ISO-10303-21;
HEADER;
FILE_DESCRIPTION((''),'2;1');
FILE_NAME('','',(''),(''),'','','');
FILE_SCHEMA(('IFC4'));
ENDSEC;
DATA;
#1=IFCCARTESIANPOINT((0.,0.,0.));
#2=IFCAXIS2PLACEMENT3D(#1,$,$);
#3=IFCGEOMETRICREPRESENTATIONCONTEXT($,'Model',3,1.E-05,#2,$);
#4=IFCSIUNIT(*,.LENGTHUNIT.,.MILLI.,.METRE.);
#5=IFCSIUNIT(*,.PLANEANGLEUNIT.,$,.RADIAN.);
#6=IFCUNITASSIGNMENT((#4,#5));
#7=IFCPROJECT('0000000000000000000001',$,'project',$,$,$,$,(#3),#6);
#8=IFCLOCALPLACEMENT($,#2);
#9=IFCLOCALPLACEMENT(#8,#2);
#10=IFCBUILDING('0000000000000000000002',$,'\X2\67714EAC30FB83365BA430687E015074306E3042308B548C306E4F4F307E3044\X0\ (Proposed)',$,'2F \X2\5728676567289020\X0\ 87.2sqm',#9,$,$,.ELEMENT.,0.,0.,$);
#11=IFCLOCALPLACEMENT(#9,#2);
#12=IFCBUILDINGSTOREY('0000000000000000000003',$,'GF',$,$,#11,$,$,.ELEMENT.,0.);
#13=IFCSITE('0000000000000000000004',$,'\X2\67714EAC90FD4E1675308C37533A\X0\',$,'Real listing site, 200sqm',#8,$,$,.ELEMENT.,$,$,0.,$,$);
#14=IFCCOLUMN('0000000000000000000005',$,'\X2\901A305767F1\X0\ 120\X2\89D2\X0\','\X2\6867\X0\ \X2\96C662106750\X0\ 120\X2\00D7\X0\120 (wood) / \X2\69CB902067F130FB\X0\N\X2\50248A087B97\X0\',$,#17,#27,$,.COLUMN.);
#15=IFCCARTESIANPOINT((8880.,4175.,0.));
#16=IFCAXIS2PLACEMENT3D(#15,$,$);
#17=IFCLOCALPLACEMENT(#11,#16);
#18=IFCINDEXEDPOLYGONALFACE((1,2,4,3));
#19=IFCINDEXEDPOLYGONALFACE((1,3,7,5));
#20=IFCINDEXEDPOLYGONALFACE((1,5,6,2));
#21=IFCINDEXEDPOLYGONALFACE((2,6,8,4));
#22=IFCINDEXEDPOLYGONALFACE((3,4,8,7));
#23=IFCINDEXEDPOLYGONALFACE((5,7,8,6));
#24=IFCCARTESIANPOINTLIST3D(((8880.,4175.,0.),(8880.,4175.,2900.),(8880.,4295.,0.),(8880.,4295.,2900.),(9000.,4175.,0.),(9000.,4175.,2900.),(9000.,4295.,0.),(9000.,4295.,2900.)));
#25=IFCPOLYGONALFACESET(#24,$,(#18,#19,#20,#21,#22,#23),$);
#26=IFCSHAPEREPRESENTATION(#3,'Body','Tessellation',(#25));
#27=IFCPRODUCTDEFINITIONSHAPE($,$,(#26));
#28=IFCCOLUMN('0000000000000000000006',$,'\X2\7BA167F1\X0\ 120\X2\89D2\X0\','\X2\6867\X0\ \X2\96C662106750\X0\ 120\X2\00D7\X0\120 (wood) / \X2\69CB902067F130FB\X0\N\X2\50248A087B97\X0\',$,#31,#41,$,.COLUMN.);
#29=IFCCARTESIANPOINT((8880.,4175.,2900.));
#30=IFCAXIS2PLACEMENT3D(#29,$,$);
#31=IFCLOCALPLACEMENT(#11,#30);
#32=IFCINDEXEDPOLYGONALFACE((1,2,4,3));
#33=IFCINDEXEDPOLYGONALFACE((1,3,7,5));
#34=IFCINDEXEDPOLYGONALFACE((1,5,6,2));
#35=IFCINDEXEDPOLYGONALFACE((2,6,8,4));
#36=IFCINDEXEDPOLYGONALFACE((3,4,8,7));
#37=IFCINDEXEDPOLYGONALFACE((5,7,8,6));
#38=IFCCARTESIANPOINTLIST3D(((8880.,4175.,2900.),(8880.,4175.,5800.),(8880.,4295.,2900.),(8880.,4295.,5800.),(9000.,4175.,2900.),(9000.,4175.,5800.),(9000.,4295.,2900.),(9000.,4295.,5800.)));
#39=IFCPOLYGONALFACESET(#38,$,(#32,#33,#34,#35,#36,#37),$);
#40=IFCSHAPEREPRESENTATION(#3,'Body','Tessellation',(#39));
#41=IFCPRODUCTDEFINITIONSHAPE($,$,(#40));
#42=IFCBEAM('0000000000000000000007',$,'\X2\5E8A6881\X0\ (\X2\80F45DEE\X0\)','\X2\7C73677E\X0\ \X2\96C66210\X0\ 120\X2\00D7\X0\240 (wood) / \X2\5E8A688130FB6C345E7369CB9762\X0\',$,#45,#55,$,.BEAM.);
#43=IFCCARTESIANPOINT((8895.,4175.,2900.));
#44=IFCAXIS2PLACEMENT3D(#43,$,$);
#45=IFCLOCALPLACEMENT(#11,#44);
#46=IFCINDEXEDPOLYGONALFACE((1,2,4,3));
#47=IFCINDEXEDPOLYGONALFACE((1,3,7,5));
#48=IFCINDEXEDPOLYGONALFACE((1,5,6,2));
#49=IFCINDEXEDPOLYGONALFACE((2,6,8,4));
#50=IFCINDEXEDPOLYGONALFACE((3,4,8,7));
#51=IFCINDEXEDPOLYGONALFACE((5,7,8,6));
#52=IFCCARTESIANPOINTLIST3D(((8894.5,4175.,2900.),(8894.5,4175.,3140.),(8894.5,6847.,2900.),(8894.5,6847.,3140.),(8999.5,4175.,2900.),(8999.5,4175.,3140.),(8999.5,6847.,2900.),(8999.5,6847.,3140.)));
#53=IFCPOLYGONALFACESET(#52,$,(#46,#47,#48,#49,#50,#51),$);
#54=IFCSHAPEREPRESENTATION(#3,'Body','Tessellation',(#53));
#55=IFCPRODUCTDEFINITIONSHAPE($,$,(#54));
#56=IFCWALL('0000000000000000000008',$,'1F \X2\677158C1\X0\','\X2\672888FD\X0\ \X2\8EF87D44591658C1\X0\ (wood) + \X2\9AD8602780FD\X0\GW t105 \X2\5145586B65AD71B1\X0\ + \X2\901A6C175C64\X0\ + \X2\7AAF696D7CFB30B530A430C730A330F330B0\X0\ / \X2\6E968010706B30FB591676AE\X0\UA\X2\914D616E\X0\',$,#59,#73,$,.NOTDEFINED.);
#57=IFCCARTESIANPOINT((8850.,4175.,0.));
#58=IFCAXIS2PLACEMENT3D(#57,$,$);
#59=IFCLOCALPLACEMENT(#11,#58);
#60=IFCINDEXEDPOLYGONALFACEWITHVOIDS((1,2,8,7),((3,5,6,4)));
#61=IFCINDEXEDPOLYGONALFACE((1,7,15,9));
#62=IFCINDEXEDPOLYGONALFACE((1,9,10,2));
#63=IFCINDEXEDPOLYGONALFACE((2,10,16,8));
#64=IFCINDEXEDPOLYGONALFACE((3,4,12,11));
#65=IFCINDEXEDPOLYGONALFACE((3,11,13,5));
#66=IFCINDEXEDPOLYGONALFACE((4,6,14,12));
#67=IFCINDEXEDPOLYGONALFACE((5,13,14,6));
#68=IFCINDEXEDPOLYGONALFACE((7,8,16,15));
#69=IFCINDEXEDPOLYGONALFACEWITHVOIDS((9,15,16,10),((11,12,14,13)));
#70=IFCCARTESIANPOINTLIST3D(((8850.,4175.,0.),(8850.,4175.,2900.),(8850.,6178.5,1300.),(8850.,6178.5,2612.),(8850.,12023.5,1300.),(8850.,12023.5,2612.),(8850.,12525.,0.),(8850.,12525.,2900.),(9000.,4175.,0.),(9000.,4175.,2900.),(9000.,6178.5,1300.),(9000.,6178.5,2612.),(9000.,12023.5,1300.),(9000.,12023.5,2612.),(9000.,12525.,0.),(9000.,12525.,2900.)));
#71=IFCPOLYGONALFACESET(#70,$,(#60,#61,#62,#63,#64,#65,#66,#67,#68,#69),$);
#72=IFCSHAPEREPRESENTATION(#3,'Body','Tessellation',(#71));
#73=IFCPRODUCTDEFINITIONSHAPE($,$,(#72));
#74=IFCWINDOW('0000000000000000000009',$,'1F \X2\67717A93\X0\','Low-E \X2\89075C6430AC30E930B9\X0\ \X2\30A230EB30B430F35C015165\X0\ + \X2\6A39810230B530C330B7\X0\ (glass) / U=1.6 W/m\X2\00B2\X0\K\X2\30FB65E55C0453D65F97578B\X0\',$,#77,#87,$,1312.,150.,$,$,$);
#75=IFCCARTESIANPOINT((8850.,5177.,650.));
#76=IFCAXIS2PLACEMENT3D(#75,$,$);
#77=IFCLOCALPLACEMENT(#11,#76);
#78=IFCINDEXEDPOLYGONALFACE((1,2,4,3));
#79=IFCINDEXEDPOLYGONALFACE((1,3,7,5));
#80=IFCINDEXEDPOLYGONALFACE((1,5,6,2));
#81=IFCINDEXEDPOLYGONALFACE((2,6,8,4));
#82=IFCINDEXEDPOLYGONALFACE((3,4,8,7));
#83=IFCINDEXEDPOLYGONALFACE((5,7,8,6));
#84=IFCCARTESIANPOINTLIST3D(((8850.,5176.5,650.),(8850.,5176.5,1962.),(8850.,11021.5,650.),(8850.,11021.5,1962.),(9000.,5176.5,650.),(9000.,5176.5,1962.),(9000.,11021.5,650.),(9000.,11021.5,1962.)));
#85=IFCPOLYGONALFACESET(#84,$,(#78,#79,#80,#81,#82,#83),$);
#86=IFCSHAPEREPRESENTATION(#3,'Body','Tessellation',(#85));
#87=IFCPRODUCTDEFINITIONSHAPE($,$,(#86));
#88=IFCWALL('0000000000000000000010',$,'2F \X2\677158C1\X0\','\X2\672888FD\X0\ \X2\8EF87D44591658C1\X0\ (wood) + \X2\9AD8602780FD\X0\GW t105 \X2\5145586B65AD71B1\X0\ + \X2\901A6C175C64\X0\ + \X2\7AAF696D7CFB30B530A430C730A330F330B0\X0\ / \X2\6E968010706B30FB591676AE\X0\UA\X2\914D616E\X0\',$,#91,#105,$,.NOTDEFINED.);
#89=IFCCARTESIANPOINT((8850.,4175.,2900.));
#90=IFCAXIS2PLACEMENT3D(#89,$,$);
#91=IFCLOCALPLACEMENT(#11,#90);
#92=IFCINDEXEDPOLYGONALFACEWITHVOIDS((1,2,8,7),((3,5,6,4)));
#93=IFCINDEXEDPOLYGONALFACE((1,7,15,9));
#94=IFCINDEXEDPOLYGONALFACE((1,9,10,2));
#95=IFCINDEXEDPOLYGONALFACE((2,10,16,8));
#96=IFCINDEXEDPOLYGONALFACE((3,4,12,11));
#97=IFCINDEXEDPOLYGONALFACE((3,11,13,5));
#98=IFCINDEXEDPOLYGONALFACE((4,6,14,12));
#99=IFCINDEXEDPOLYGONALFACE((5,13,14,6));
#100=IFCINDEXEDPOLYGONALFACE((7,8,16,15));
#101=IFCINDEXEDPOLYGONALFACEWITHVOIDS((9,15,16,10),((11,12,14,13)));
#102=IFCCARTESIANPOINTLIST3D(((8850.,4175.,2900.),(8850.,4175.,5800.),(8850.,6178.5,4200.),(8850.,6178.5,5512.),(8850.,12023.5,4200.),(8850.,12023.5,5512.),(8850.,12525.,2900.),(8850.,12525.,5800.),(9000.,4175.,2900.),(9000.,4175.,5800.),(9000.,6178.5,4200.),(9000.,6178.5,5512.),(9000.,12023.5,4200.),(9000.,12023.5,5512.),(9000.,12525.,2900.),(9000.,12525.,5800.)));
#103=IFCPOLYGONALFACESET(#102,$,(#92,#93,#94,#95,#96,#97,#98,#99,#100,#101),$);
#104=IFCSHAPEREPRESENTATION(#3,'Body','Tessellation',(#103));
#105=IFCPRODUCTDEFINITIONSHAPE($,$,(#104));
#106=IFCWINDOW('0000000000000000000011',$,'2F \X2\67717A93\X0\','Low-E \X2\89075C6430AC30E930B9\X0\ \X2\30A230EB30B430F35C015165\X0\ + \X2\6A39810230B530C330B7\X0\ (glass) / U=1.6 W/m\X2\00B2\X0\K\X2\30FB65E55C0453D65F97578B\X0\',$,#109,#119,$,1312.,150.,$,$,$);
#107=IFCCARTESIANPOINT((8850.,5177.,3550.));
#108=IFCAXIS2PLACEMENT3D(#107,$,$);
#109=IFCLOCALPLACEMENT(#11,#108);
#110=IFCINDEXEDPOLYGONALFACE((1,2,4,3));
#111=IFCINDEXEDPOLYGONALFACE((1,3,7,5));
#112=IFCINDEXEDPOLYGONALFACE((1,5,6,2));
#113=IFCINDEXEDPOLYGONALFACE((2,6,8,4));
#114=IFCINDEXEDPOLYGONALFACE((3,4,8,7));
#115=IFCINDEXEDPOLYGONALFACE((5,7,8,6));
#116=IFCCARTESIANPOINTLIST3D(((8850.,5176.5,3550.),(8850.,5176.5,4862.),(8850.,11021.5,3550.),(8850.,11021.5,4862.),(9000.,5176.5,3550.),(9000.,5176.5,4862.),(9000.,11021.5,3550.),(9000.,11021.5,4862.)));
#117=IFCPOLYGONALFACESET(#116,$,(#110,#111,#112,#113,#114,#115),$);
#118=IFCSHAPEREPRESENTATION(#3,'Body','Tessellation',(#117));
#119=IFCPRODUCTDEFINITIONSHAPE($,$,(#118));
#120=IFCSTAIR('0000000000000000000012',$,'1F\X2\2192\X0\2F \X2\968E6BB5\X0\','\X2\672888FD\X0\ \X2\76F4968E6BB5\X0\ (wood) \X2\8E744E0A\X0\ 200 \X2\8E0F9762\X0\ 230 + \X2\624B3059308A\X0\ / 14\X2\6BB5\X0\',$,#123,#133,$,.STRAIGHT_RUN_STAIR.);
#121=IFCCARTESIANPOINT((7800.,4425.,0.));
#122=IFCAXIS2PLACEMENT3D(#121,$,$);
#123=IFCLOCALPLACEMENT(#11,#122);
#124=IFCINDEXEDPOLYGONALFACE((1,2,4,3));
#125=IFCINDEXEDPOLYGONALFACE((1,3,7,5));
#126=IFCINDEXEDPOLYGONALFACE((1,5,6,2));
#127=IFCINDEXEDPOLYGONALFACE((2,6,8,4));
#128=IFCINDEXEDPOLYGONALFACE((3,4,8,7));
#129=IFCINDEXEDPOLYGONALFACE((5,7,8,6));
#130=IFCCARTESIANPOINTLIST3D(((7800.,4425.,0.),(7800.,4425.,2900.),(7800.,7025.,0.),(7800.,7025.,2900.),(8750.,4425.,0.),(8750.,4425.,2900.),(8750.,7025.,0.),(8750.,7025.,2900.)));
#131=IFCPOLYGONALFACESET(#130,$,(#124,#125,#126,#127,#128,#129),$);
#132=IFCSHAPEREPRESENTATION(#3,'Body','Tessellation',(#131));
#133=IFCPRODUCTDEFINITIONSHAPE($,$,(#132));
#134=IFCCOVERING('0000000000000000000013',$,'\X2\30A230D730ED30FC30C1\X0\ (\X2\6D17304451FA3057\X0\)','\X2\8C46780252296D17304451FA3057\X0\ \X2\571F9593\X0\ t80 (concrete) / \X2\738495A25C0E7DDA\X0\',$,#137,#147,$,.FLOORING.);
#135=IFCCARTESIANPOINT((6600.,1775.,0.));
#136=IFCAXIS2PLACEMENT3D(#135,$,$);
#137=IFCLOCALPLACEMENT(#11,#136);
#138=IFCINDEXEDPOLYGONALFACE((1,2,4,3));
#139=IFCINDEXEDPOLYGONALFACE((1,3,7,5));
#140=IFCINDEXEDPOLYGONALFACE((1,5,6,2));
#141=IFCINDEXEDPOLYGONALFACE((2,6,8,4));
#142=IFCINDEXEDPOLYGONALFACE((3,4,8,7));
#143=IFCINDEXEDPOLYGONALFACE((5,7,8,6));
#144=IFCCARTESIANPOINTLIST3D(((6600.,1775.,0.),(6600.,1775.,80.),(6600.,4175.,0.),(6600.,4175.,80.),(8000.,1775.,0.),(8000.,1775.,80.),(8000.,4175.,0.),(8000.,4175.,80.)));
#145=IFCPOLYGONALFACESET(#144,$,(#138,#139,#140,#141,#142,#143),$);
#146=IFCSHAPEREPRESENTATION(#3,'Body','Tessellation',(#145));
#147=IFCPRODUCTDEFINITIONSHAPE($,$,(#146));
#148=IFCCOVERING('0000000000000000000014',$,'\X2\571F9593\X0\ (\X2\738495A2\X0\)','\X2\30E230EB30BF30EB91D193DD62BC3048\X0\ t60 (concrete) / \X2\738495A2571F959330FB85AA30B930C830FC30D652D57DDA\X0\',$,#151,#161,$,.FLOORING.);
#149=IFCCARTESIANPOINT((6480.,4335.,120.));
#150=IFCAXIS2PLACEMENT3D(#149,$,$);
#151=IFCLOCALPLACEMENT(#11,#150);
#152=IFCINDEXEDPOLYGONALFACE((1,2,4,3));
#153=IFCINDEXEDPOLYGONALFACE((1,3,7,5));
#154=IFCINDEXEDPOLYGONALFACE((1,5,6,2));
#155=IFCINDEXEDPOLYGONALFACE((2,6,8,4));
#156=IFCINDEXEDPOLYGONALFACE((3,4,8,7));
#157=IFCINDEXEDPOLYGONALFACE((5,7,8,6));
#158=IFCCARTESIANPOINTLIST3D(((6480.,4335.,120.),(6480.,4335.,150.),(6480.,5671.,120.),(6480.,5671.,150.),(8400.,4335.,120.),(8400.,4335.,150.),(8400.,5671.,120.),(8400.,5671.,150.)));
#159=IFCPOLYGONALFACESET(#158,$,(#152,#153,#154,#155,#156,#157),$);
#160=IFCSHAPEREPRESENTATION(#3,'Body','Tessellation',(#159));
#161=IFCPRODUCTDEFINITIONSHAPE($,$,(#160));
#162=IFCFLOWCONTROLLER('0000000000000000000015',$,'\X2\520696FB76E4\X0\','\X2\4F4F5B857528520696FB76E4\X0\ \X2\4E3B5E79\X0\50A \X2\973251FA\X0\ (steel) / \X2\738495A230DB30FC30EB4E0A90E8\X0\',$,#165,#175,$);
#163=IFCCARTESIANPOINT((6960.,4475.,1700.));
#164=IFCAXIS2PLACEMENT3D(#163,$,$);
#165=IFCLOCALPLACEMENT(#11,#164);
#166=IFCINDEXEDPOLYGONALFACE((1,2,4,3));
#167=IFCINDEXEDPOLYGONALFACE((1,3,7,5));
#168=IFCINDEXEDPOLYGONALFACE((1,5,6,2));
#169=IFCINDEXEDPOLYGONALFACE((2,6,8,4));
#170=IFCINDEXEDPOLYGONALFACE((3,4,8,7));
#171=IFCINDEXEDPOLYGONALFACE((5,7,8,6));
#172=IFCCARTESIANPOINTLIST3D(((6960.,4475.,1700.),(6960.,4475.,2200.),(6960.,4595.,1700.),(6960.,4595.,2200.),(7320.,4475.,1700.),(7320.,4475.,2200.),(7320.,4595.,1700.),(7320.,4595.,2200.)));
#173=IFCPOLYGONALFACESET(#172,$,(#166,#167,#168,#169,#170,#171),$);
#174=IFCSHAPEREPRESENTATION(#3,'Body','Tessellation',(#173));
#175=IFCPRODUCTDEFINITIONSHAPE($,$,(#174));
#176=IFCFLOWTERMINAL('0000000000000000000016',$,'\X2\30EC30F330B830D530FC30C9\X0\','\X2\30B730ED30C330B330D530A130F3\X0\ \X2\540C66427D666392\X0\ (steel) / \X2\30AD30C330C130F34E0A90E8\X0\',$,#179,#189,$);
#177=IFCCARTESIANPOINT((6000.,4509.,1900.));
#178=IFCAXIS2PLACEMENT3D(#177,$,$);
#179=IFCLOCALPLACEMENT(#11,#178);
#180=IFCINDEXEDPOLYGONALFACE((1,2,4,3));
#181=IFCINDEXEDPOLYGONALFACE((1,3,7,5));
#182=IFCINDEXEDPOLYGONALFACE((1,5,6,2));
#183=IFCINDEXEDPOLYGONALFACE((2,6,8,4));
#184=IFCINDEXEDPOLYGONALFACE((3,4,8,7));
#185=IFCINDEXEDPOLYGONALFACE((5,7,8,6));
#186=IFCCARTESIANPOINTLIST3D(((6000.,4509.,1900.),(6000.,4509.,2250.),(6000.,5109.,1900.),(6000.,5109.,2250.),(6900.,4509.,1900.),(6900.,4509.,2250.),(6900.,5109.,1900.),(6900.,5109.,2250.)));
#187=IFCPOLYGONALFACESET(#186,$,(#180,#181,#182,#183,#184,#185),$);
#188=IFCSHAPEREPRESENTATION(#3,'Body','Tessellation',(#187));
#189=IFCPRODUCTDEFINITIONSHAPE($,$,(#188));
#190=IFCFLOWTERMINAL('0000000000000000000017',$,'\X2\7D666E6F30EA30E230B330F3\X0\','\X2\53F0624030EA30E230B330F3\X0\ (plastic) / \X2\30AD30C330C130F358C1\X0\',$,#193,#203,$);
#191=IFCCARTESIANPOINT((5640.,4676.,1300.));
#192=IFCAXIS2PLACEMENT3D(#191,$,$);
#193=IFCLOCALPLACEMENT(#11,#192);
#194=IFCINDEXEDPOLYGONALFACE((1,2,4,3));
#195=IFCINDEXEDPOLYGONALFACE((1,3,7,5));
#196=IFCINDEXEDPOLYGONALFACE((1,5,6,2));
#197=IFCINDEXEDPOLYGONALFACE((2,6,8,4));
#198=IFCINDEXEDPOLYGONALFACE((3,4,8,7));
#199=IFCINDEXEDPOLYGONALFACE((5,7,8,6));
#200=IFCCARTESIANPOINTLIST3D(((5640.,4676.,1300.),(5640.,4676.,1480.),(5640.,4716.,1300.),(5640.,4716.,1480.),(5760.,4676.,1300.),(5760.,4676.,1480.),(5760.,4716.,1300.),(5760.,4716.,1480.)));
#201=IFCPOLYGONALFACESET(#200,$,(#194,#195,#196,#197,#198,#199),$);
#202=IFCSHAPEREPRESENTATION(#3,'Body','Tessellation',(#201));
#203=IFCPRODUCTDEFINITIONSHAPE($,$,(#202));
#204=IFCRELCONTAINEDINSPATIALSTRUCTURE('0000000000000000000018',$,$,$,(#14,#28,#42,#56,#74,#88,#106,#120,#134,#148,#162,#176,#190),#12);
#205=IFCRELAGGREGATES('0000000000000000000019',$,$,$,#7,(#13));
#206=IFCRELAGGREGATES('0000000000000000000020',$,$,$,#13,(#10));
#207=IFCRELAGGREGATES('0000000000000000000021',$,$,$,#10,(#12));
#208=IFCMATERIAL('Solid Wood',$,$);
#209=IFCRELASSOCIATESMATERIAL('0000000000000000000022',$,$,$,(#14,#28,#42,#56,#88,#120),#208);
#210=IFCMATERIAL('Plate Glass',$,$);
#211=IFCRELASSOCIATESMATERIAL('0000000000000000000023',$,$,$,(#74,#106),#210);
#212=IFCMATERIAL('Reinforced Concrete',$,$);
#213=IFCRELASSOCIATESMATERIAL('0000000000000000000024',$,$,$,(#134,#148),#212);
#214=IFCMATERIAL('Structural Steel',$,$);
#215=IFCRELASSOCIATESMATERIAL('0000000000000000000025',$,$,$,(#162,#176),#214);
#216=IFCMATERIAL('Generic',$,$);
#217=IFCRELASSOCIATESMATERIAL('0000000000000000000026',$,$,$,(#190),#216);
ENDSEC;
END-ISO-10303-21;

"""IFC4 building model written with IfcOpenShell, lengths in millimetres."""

from ifc_helpers import new_model, si_unit, frame, frame_2d, origin, place, context, project, spatial, rectangle, extrude, material, element, fill, save


model = new_model("IFC4")

# Units and contexts
model_context = context("Model", 3, precision=1e-05, world=origin())
ifc_project = project(units=[si_unit("LENGTHUNIT", "METRE", prefix="MILLI"), si_unit("PLANEANGLEUNIT", "RADIAN")], contexts=[model_context])

# Site, building, storey
site_placement = place(None, origin())
site = spatial("IfcSite", under=ifc_project, at=site_placement, Name="東京都世田谷区", ObjectType="Real listing site, 200sqm", CompositionType="ELEMENT", RefElevation=0.0)
building_placement = place(site_placement, origin())
building = spatial("IfcBuilding", under=site, at=building_placement, Name="東京・茶室と縁側のある和の住まい (Proposed)", ObjectType="2F 在来木造 87.2sqm", CompositionType="ELEMENT", ElevationOfRefHeight=0.0, ElevationOfTerrain=0.0)
storey_placement = place(building_placement, origin())
storey = spatial("IfcBuildingStorey", under=building, at=storey_placement, Name="GF", CompositionType="ELEMENT", Elevation=0.0)

# Columns
ifc_material_1 = material(Name="Solid Wood")
column_1_placement = place(storey_placement, frame((8880.0, 4175.0, 0.0)))
element("IfcColumn", 1, at=column_1_placement, inside=storey, material=ifc_material_1, Name="通し柱 120角", Description="桧 集成材 120×120 (wood) / 構造柱・N値計算", PredefinedType="COLUMN", context=model_context, shape_type="SweptSolid", body=[
    extrude(rectangle(XDim=120.0, YDim=120.0, at=frame_2d((60.0, 60.0))), frame((8880.0, 4175.0, 0.0)), (0.0, 0.0, 1.0), 2900.0),
])
column_2_placement = place(storey_placement, frame((8880.0, 4175.0, 2900.0)))
element("IfcColumn", 2, at=column_2_placement, inside=storey, material=ifc_material_1, Name="管柱 120角", Description="桧 集成材 120×120 (wood) / 構造柱・N値計算", PredefinedType="COLUMN", context=model_context, shape_type="SweptSolid", body=[
    extrude(rectangle(XDim=120.0, YDim=120.0, at=frame_2d((60.0, 60.0))), frame((8880.0, 4175.0, 2900.0)), (0.0, 0.0, 1.0), 2900.0),
])

# Beam
beam_1_placement = place(storey_placement, frame((8895.0, 4175.0, 2900.0)))
element("IfcBeam", 3, at=beam_1_placement, inside=storey, material=ifc_material_1, Name="床梁 (胴差)", Description="米松 集成 120×240 (wood) / 床梁・水平構面", PredefinedType="BEAM", context=model_context, shape_type="SweptSolid", body=[
    extrude(rectangle(XDim=105.0, YDim=2672.0, at=frame_2d((52.0, 1336.0))), frame((8895.0, 4175.0, 2900.0)), (0.0, 0.0, 1.0), 240.0),
])

# Wall, opening, window
wall_1_placement = place(storey_placement, frame((8850.0, 4175.0, 0.0)))
wall_1 = element("IfcWall", 4, at=wall_1_placement, inside=storey, material=ifc_material_1, Name="1F 東壁", Description="木製 軸組外壁 (wood) + 高性能GW t105 充填断熱 + 通気層 + 窯業系サイディング / 準耐火・外皮UA配慮", PredefinedType="NOTDEFINED", context=model_context, shape_type="SweptSolid", body=[
    extrude(rectangle(XDim=150.0, YDim=8350.0, at=frame_2d((75.0, 4175.0))), frame((8850.0, 4175.0, 0.0)), (0.0, 0.0, 1.0), 2900.0),
])
opening_1_placement = place(storey_placement, frame((8850.0, 5177.0, 650.0)))
opening_1 = element("IfcOpeningElement", 5, at=opening_1_placement, cuts=wall_1, PredefinedType="NOTDEFINED", context=model_context, shape_type="SweptSolid", body=[
    extrude(rectangle(XDim=150.0, YDim=5845.0, at=frame_2d((75.0, 2922.0))), frame((8850.0, 5177.0, 650.0)), (0.0, 0.0, 1.0), 1312.0),
])
ifc_material_2 = material(Name="Plate Glass")
window_1_placement = place(storey_placement, frame((8850.0, 5177.0, 650.0)))
window_1 = element("IfcWindow", 6, at=window_1_placement, inside=storey, material=ifc_material_2, Name="1F 東窓", Description="Low-E 複層ガラス アルゴン封入 + 樹脂サッシ (glass) / U=1.6 W/m²K・日射取得型", OverallHeight=1312.0, OverallWidth=150.0, context=model_context, shape_type="SweptSolid", body=[
    extrude(rectangle(XDim=150.0, YDim=5845.0, at=frame_2d((75.0, 2922.0))), frame((8850.0, 5177.0, 650.0)), (0.0, 0.0, 1.0), 1312.0),
])
fill(opening_1, window_1)

# Wall, opening, window
wall_2_placement = place(storey_placement, frame((8850.0, 4175.0, 2900.0)))
wall_2 = element("IfcWall", 7, at=wall_2_placement, inside=storey, material=ifc_material_1, Name="2F 東壁", Description="木製 軸組外壁 (wood) + 高性能GW t105 充填断熱 + 通気層 + 窯業系サイディング / 準耐火・外皮UA配慮", PredefinedType="NOTDEFINED", context=model_context, shape_type="SweptSolid", body=[
    extrude(rectangle(XDim=150.0, YDim=8350.0, at=frame_2d((75.0, 4175.0))), frame((8850.0, 4175.0, 2900.0)), (0.0, 0.0, 1.0), 2900.0),
])
opening_2_placement = place(storey_placement, frame((8850.0, 5177.0, 3550.0)))
opening_2 = element("IfcOpeningElement", 8, at=opening_2_placement, cuts=wall_2, PredefinedType="NOTDEFINED", context=model_context, shape_type="SweptSolid", body=[
    extrude(rectangle(XDim=150.0, YDim=5845.0, at=frame_2d((75.0, 2922.0))), frame((8850.0, 5177.0, 3550.0)), (0.0, 0.0, 1.0), 1312.0),
])
window_2_placement = place(storey_placement, frame((8850.0, 5177.0, 3550.0)))
window_2 = element("IfcWindow", 9, at=window_2_placement, inside=storey, material=ifc_material_2, Name="2F 東窓", Description="Low-E 複層ガラス アルゴン封入 + 樹脂サッシ (glass) / U=1.6 W/m²K・日射取得型", OverallHeight=1312.0, OverallWidth=150.0, context=model_context, shape_type="SweptSolid", body=[
    extrude(rectangle(XDim=150.0, YDim=5845.0, at=frame_2d((75.0, 2922.0))), frame((8850.0, 5177.0, 3550.0)), (0.0, 0.0, 1.0), 1312.0),
])
fill(opening_2, window_2)

# Stair
stair_placement = place(storey_placement, frame((7800.0, 4425.0, 0.0)))
element("IfcStair", 10, at=stair_placement, inside=storey, material=ifc_material_1, Name="1F→2F 階段", Description="木製 直階段 (wood) 蹴上 200 踏面 230 + 手すり / 14段", PredefinedType="STRAIGHT_RUN_STAIR", context=model_context, shape_type="SweptSolid", body=[
    extrude(rectangle(XDim=950.0, YDim=2600.0, at=frame_2d((475.0, 1300.0))), frame((7800.0, 4425.0, 0.0)), (0.0, 0.0, 1.0), 2900.0),
])

# Coverings
ifc_material_3 = material(Name="Reinforced Concrete")
covering_1_placement = place(storey_placement, frame((6600.0, 1775.0, 0.0)))
element("IfcCovering", 11, at=covering_1_placement, inside=storey, material=ifc_material_3, Name="アプローチ (洗い出し)", Description="豆砂利洗い出し 土間 t80 (concrete) / 玄関導線", PredefinedType="FLOORING", context=model_context, shape_type="SweptSolid", body=[
    extrude(rectangle(XDim=1400.0, YDim=2400.0, at=frame_2d((700.0, 1200.0))), frame((6600.0, 1775.0, 0.0)), (0.0, 0.0, 1.0), 80.0),
])
covering_2_placement = place(storey_placement, frame((6480.0, 4335.0, 120.0)))
element("IfcCovering", 12, at=covering_2_placement, inside=storey, material=ifc_material_3, Name="土間 (玄関)", Description="モルタル金鏝押え t60 (concrete) / 玄関土間・薪ストーブ動線", PredefinedType="FLOORING", context=model_context, shape_type="SweptSolid", body=[
    extrude(rectangle(XDim=1920.0, YDim=1336.0, at=frame_2d((960.0, 668.0))), frame((6480.0, 4335.0, 120.0)), (0.0, 0.0, 1.0), 30.0),
])

# Flow controller
ifc_material_4 = material(Name="Structural Steel")
flow_controller_placement = place(storey_placement, frame((6960.0, 4475.0, 1700.0)))
element("IfcFlowController", 13, at=flow_controller_placement, inside=storey, material=ifc_material_4, Name="分電盤", Description="住宅用分電盤 主幹50A 露出 (steel) / 玄関ホール上部", context=model_context, shape_type="SweptSolid", body=[
    extrude(rectangle(XDim=360.0, YDim=120.0, at=frame_2d((180.0, 60.0))), frame((6960.0, 4475.0, 1700.0)), (0.0, 0.0, 1.0), 500.0),
])

# Flow terminals
flow_terminal_1_placement = place(storey_placement, frame((6000.0, 4509.0, 1900.0)))
element("IfcFlowTerminal", 14, at=flow_terminal_1_placement, inside=storey, material=ifc_material_4, Name="レンジフード", Description="シロッコファン 同時給排 (steel) / キッチン上部", context=model_context, shape_type="SweptSolid", body=[
    extrude(rectangle(XDim=900.0, YDim=600.0, at=frame_2d((450.0, 300.0))), frame((6000.0, 4509.0, 1900.0)), (0.0, 0.0, 1.0), 350.0),
])
ifc_material_5 = material(Name="Generic")
flow_terminal_2_placement = place(storey_placement, frame((5640.0, 4676.0, 1300.0)))
element("IfcFlowTerminal", 15, at=flow_terminal_2_placement, inside=storey, material=ifc_material_5, Name="給湯リモコン", Description="台所リモコン (plastic) / キッチン壁", context=model_context, shape_type="SweptSolid", body=[
    extrude(rectangle(XDim=120.0, YDim=40.0, at=frame_2d((60.0, 20.0))), frame((5640.0, 4676.0, 1300.0)), (0.0, 0.0, 1.0), 180.0),
])

save(model, "model.ifc")
